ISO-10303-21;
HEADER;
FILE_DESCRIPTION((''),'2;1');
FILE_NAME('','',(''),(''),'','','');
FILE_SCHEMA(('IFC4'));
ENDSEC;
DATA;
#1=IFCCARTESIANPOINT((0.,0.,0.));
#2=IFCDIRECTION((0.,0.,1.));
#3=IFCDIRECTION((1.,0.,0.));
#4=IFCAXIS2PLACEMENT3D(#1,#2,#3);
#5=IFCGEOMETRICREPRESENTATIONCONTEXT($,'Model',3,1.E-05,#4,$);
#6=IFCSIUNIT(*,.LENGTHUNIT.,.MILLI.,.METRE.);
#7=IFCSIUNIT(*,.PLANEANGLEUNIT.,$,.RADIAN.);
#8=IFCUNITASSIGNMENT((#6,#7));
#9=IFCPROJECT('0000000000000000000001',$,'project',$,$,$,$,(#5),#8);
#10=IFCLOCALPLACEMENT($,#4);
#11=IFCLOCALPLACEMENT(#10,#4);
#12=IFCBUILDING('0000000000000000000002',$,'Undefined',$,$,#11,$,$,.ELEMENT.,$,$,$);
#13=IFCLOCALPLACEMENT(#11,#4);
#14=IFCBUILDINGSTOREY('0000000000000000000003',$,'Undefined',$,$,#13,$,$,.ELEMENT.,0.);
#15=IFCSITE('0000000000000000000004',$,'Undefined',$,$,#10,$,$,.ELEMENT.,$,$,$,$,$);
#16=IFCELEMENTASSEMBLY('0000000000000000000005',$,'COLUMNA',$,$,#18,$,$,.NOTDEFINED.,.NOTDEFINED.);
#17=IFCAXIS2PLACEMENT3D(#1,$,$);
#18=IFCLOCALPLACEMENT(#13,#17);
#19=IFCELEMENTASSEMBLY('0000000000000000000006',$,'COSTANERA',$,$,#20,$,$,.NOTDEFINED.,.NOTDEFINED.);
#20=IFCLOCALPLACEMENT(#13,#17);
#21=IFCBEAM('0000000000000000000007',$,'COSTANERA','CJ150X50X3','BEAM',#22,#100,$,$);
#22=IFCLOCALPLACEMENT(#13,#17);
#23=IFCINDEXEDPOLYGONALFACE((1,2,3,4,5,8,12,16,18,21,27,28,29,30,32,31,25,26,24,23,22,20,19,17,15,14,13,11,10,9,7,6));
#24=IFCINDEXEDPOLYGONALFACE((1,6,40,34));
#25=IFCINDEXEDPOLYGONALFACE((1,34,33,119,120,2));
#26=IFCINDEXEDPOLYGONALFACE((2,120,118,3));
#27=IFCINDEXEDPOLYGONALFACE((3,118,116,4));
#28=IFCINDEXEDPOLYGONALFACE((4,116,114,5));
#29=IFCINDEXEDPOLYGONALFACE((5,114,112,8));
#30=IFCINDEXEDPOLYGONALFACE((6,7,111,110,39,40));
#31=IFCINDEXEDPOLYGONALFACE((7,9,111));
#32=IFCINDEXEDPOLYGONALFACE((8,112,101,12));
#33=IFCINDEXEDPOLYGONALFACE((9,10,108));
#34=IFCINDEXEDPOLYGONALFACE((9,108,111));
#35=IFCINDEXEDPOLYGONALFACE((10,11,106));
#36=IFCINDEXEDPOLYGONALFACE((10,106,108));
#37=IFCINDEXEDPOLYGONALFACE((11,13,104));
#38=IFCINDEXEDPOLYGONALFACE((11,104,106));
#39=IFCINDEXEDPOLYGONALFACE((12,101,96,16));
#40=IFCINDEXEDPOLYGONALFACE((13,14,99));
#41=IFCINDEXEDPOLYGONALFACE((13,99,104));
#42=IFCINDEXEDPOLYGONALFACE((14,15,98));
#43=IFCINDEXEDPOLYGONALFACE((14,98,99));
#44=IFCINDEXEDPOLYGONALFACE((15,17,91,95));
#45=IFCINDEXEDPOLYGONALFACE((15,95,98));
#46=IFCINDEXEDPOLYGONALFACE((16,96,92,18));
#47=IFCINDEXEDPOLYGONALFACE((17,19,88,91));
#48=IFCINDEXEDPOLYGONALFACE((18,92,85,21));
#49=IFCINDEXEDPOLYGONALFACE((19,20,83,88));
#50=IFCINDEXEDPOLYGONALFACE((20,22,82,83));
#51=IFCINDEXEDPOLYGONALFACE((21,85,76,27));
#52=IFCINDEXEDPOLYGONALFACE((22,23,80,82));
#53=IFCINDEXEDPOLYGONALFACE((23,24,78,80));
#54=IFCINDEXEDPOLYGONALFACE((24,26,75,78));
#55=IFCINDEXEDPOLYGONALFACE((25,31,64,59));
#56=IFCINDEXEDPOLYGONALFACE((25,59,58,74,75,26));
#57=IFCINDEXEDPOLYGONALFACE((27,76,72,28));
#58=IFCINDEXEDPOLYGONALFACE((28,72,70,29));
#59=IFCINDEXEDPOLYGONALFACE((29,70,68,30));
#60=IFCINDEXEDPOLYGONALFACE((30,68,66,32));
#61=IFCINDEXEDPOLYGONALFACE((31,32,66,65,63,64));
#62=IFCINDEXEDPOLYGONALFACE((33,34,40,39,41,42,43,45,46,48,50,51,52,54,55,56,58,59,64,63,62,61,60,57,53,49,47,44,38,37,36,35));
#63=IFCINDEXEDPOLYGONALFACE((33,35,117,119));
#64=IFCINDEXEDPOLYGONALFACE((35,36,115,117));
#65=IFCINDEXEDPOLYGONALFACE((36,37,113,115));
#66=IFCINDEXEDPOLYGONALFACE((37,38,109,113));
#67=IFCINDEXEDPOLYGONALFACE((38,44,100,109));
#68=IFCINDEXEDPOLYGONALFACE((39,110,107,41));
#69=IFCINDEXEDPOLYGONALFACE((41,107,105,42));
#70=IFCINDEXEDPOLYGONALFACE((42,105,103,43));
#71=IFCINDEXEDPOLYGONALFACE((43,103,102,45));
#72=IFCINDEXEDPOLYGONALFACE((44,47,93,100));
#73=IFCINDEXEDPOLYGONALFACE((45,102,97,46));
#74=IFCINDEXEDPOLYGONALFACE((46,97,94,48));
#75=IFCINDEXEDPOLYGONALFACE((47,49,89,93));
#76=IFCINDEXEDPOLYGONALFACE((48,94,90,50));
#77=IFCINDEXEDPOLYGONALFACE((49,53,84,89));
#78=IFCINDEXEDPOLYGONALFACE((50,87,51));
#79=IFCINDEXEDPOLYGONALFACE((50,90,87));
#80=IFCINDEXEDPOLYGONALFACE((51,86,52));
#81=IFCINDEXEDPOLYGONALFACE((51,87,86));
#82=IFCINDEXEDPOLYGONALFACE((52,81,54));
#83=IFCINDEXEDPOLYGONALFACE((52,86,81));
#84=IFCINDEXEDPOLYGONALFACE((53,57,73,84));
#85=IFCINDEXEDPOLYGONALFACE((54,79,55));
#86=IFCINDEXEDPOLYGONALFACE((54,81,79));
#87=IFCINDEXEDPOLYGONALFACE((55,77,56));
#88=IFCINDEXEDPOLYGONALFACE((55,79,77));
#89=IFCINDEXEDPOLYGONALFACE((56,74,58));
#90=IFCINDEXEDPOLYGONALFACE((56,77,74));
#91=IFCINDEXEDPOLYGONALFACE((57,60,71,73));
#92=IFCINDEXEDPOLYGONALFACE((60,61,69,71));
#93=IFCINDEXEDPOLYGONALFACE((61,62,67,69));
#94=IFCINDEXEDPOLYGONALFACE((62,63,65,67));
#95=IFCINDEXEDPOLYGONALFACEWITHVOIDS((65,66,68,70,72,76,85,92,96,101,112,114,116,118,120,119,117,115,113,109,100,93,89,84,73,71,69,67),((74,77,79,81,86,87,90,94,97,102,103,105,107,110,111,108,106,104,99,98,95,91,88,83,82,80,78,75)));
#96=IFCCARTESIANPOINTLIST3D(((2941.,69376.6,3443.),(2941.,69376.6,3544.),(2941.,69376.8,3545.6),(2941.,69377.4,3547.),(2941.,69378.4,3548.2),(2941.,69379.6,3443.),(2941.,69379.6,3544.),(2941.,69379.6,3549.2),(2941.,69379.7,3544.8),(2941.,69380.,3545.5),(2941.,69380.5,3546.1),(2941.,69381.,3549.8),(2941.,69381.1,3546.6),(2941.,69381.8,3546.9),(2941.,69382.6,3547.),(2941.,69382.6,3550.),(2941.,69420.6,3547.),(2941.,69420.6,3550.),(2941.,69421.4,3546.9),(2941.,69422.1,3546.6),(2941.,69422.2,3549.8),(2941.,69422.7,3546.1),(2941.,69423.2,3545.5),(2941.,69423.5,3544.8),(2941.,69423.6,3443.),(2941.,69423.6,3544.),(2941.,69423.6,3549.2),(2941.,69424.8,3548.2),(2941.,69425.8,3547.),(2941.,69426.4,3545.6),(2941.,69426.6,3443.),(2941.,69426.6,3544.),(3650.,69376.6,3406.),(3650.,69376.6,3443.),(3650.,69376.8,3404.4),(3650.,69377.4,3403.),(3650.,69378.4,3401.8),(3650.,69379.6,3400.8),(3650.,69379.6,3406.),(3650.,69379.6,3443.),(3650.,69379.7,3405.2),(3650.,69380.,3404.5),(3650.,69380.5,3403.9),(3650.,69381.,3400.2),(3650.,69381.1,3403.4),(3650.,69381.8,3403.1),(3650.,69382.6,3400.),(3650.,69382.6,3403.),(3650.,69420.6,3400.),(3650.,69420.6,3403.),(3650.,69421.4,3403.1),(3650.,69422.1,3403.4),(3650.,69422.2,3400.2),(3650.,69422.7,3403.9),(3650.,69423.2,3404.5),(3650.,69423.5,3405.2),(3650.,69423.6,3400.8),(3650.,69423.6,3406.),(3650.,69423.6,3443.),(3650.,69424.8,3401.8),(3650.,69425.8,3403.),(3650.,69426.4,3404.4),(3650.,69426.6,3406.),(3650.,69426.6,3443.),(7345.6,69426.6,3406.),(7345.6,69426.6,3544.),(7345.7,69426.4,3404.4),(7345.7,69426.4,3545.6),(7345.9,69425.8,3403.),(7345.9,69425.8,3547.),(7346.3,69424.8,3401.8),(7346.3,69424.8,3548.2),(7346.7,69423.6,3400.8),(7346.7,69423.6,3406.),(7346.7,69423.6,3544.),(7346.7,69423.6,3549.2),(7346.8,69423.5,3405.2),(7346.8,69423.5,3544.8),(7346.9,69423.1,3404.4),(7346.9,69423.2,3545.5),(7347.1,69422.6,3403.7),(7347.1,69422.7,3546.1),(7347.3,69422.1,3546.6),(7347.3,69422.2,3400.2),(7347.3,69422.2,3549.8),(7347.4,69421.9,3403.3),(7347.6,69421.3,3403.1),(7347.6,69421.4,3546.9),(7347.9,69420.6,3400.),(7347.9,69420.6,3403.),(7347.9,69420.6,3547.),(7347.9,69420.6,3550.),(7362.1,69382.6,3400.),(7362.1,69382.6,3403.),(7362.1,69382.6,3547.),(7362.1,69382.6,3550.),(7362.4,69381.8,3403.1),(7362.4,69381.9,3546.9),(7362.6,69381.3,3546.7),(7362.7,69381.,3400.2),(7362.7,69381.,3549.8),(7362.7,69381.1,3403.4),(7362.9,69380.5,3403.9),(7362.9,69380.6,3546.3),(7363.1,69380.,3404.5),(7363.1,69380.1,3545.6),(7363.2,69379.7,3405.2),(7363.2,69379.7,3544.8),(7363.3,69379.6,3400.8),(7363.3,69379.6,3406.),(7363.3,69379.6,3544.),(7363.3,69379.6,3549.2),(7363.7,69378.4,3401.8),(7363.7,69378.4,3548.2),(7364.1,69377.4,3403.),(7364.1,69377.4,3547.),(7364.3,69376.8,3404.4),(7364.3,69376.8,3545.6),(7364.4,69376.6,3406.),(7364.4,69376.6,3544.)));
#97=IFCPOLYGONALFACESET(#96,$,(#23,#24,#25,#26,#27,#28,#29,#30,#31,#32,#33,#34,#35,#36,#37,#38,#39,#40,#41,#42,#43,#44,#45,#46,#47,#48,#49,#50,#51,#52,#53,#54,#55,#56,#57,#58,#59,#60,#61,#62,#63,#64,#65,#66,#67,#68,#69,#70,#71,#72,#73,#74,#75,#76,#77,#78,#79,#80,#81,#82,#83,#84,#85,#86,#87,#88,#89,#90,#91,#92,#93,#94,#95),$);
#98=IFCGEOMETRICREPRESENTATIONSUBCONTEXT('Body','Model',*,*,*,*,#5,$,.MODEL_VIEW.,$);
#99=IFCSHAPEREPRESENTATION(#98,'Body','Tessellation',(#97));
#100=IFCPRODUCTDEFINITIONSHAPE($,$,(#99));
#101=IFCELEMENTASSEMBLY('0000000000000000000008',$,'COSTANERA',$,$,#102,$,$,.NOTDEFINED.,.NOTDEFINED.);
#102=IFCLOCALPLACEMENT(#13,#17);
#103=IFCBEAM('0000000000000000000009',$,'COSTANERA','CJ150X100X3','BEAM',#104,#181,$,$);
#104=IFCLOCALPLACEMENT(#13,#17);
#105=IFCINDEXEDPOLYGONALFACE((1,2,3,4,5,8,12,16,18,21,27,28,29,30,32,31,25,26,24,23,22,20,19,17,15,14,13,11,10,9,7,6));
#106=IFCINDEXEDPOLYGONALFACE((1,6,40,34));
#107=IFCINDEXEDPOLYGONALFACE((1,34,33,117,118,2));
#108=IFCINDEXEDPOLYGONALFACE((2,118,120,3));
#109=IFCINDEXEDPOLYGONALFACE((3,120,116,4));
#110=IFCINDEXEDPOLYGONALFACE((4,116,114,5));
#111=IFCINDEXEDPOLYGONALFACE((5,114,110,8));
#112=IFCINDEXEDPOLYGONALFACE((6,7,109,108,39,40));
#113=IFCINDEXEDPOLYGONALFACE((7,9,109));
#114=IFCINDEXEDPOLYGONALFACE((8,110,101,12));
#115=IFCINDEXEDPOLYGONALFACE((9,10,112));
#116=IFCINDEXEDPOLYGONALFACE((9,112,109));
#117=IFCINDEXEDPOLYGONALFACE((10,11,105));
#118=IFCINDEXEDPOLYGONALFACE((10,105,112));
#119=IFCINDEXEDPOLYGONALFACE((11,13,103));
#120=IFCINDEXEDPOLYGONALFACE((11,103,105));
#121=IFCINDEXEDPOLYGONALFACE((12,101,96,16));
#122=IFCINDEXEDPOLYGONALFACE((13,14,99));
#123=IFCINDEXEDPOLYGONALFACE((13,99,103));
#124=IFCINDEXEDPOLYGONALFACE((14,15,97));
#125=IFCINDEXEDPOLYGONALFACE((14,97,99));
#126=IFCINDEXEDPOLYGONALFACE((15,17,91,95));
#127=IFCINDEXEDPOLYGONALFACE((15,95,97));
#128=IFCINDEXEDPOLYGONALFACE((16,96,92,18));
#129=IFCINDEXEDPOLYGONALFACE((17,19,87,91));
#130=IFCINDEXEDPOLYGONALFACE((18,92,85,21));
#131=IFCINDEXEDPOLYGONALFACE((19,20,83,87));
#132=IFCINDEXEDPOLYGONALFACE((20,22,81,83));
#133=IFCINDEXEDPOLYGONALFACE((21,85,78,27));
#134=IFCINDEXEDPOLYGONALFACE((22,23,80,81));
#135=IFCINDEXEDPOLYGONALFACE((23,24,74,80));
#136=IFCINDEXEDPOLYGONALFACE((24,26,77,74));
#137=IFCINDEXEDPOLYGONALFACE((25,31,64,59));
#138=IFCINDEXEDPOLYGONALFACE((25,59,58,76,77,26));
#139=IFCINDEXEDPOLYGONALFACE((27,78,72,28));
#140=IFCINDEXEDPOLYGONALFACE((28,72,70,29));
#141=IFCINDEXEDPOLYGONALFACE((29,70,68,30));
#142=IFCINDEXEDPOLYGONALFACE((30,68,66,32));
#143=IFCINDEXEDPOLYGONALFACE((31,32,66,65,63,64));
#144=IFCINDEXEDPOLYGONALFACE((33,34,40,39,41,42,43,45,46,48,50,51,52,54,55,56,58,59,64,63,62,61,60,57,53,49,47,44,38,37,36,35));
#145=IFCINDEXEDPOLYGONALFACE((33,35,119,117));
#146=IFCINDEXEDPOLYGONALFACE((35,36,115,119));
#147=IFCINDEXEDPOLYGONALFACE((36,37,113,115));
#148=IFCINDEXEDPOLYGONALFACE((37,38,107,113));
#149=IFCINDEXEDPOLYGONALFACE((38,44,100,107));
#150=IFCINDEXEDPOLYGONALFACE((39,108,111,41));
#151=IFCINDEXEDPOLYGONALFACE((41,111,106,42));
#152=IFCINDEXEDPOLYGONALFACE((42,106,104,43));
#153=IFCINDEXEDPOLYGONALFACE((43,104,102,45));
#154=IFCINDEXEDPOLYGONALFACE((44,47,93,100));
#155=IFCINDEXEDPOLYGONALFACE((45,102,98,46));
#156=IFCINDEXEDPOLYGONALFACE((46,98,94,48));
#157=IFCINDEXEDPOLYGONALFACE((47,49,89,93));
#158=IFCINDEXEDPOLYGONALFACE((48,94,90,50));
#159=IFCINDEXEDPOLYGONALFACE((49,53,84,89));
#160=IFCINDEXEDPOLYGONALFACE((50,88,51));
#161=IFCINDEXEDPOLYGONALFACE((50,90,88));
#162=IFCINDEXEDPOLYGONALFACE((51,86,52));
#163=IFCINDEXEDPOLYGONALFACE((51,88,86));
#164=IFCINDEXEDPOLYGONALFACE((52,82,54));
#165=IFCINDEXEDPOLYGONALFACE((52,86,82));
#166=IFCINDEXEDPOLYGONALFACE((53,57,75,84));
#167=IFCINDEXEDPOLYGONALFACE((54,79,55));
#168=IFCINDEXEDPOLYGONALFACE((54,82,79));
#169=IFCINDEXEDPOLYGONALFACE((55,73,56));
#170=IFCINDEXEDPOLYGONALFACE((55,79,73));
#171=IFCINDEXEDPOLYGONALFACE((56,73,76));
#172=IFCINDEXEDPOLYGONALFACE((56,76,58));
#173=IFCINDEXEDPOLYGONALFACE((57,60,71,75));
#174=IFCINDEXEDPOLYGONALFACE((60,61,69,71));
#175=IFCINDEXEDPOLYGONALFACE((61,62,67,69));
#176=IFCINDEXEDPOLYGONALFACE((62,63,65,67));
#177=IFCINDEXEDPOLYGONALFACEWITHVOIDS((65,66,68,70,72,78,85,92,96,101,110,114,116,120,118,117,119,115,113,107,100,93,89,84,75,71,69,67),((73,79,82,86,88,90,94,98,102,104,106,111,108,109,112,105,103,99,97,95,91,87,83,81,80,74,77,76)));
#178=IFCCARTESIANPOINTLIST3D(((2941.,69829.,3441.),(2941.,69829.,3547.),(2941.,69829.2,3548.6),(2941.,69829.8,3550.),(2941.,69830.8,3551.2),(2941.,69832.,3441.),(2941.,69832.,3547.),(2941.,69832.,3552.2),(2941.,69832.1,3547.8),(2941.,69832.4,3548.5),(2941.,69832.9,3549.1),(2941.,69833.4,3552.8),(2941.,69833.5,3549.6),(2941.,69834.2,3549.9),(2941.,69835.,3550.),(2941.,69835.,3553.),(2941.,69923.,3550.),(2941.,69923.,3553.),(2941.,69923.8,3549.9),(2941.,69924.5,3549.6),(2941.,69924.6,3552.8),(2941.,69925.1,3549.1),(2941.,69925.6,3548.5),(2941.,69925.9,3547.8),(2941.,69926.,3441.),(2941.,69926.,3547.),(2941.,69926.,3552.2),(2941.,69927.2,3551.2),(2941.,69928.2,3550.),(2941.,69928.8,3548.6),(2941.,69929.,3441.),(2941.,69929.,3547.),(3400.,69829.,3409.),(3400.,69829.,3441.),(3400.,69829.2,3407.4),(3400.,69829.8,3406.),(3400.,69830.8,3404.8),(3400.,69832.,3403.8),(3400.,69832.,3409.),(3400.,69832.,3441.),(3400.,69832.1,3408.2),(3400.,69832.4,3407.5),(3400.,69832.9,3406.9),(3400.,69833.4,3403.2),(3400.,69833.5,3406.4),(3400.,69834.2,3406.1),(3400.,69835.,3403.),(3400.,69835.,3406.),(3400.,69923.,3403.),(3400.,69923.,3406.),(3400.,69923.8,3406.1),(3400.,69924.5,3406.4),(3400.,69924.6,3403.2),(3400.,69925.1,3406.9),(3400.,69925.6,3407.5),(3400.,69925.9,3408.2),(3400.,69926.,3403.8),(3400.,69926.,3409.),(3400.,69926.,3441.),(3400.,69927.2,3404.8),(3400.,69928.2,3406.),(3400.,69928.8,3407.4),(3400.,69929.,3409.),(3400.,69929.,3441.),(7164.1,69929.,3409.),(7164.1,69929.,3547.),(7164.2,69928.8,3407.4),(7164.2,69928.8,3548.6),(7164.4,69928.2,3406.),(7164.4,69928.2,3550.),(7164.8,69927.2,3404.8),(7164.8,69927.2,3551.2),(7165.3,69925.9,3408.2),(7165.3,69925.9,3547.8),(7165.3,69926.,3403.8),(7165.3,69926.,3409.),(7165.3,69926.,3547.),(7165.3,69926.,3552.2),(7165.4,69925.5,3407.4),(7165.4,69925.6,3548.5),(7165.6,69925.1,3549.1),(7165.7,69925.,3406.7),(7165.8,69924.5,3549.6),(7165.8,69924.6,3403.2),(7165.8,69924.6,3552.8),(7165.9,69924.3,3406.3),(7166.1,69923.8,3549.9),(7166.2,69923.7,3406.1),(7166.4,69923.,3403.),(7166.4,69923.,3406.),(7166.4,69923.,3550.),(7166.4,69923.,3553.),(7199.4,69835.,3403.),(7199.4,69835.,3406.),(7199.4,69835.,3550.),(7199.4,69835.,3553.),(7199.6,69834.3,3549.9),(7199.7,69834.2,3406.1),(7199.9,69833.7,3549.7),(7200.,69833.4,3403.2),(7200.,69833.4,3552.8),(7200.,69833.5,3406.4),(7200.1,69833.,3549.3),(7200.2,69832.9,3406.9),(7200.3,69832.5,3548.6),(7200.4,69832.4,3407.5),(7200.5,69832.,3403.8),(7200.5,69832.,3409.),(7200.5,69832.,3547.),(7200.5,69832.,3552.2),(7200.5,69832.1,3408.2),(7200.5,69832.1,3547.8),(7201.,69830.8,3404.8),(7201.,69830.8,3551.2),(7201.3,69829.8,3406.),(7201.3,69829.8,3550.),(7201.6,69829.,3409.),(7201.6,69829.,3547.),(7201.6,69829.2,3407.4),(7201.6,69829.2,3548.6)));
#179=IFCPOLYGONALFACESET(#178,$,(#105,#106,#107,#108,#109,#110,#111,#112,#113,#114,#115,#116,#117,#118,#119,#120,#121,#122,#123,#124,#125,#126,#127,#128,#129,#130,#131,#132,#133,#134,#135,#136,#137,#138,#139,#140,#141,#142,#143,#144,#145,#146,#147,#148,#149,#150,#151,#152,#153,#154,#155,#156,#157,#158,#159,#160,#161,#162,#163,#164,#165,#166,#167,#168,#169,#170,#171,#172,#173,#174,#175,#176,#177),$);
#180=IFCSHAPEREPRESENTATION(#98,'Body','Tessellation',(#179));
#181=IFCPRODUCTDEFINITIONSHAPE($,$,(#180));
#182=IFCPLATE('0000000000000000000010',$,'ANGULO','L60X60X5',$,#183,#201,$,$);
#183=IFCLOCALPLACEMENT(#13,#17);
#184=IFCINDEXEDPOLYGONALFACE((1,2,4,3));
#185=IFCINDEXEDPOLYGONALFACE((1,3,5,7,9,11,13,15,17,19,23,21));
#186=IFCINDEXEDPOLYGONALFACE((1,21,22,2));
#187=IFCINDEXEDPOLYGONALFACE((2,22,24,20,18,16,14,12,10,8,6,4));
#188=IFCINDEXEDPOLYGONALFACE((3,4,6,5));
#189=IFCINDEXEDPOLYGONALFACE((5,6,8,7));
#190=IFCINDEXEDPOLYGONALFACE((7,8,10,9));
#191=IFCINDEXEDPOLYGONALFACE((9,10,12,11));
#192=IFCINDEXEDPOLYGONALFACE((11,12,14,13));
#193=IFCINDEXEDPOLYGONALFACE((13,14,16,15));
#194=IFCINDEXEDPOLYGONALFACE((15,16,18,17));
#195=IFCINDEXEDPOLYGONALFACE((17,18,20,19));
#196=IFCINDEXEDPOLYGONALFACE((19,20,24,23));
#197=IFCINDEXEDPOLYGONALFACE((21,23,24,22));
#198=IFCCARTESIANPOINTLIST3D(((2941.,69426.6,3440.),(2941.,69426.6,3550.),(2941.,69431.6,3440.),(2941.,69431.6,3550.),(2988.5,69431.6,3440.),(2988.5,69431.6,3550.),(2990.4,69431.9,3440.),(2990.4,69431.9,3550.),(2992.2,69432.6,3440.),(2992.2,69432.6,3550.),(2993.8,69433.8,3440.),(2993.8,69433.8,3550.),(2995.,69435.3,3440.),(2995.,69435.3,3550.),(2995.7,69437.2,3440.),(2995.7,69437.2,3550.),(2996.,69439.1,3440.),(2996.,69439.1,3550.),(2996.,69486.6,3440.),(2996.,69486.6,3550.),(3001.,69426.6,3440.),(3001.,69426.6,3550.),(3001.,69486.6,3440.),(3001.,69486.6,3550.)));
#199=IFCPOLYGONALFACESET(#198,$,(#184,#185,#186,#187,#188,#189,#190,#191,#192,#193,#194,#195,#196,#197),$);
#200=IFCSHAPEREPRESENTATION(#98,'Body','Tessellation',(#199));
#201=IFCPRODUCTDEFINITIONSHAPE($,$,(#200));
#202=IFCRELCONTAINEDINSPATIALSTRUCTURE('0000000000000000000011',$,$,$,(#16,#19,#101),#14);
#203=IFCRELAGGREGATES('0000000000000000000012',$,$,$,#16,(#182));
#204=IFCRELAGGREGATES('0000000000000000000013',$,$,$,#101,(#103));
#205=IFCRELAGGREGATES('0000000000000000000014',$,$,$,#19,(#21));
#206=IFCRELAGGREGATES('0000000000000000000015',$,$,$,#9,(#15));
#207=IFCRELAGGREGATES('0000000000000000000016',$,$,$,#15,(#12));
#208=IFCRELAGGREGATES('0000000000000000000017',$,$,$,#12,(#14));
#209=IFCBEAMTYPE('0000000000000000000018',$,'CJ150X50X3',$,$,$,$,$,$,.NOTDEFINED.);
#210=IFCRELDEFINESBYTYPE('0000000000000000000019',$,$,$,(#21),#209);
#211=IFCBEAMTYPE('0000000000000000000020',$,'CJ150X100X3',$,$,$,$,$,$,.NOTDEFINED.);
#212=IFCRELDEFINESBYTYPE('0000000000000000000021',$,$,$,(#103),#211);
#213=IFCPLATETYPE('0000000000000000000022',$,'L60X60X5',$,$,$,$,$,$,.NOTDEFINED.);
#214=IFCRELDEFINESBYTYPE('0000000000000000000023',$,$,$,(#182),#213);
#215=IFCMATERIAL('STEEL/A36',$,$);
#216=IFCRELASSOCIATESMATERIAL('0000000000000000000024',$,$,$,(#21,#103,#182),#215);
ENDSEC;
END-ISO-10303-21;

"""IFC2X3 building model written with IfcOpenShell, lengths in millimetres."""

from ifc_helpers import new_model, si_unit, frame, origin_with_axes, origin_2d_with_axis, place, context, subcontext, project, spatial, polyline, hollow_rectangle, l_section, outline, extrude, boolean, halfspace, material, type_object, element, aggregate, save


model = new_model("IFC2X3")

# Units and contexts
model_context = context("Model", 3, precision=1e-05, world=origin_with_axes())
body_context = subcontext(model_context, "Body", "Model", "MODEL_VIEW")
ifc_project = project(units=[si_unit("LENGTHUNIT", "METRE", prefix="MILLI"), si_unit("PLANEANGLEUNIT", "RADIAN")], contexts=[model_context])

# Site, building, storey
site_placement = place(None, origin_with_axes())
site = spatial("IfcSite", under=ifc_project, at=site_placement, Name="Undefined", CompositionType="ELEMENT")
building_placement = place(site_placement, origin_with_axes())
building = spatial("IfcBuilding", under=site, at=building_placement, Name="Undefined", CompositionType="ELEMENT")
storey_placement = place(building_placement, origin_with_axes())
storey = spatial("IfcBuildingStorey", under=building, at=storey_placement, Name="Undefined", CompositionType="ELEMENT", Elevation=0.0)

# Element assembly
assembly_1_placement = place(storey_placement, origin_with_axes())
assembly_1 = element("IfcElementAssembly", 1, at=assembly_1_placement, inside=storey, Name="COLUMNA", AssemblyPlace="NOTDEFINED", PredefinedType="NOTDEFINED")
ifc_material_1 = material(Name="STEEL/A36")

# Element assemblies, beams
assembly_2_placement = place(storey_placement, origin_with_axes())
assembly_2 = element("IfcElementAssembly", 2, at=assembly_2_placement, inside=storey, Name="COSTANERA", AssemblyPlace="NOTDEFINED", PredefinedType="NOTDEFINED")
beam_type_1 = type_object("IfcBeamType", Name="CJ150X50X3", PredefinedType="NOTDEFINED")
beam_1_placement = place(assembly_2_placement, frame((2941.0, 69401.6, 3475.0), z_axis=(0.0, 0.0, 1.0), x_axis=(1.0, 0.0, 0.0)))
beam_1 = element("IfcBeam", 3, at=beam_1_placement, type_object=beam_type_1, material=ifc_material_1, Name="COSTANERA", Description="CJ150X50X3", ObjectType="BEAM", context=body_context, shape_type="CSG", body=[
    boolean("DIFFERENCE", boolean("DIFFERENCE", extrude(hollow_rectangle(XDim=50.0, YDim=150.0, WallThickness=3.0, InnerFilletRadius=3.0, OuterFilletRadius=6.0, at=origin_2d_with_axis()), frame((4423.5, 0.0, 0.0), z_axis=(-1.0, 0.0, 0.0), x_axis=(0.0, -1.0, 0.0)), (0.0, 0.0, 1.0), 4423.5), extrude(outline(polyline([(0.0, 0.0), (896.0, 0.0), (896.0, 48.0), (0.0, 48.0), (0.0, 0.0)])), frame((-187.0, -52.5, -32.0), z_axis=(0.0, 1.0, 0.0), x_axis=(1.0, 0.0, 0.0)), (0.0, 0.0, 1.0), 105.0)), halfspace(frame((4404.6, 25.0, 0.0), z_axis=(-0.936213, -0.351433, 0.0), x_axis=(0.0, 0.0, 1.0)), True)),
])
assembly_3_placement = place(storey_placement, origin_with_axes())
assembly_3 = element("IfcElementAssembly", 4, at=assembly_3_placement, inside=storey, Name="COSTANERA", AssemblyPlace="NOTDEFINED", PredefinedType="NOTDEFINED")
beam_type_2 = type_object("IfcBeamType", Name="CJ150X100X3", PredefinedType="NOTDEFINED")
beam_2_placement = place(assembly_3_placement, frame((2941.0, 69879.0, 3478.0), z_axis=(0.0, 0.0, 1.0), x_axis=(1.0, 0.0, 0.0)))
beam_2 = element("IfcBeam", 5, at=beam_2_placement, type_object=beam_type_2, material=ifc_material_1, Name="COSTANERA", Description="CJ150X100X3", ObjectType="BEAM", context=body_context, shape_type="CSG", body=[
    boolean("DIFFERENCE", boolean("DIFFERENCE", extrude(hollow_rectangle(XDim=100.0, YDim=150.0, WallThickness=3.0, InnerFilletRadius=3.0, OuterFilletRadius=6.0, at=origin_2d_with_axis()), frame((4260.8, 0.0, 0.0), z_axis=(-1.0, 0.0, 0.0), x_axis=(0.0, -1.0, 0.0)), (0.0, 0.0, 1.0), 4260.8), extrude(outline(polyline([(0.0, 0.0), (646.0, 0.0), (646.0, 43.0), (0.0, 43.0), (0.0, 0.0)])), frame((-187.0, -52.5, -37.0), z_axis=(0.0, 1.0, 0.0), x_axis=(1.0, 0.0, 0.0)), (0.0, 0.0, 1.0), 105.0)), halfspace(frame((4223.1, 50.0, 0.0), z_axis=(-0.936354, -0.351057, 0.0), x_axis=(0.0, 0.0, 1.0)), True)),
])

# Plate
plate_type_1 = type_object("IfcPlateType", Name="L60X60X5", PredefinedType="NOTDEFINED")
plate_1_placement = place(assembly_1_placement, frame((2971.0, 69456.6, 3440.0), z_axis=(0.0, 1.0, 0.0), x_axis=(0.0, 0.0, 1.0)))
plate_1 = element("IfcPlate", 6, at=plate_1_placement, type_object=plate_type_1, material=ifc_material_1, Name="ANGULO", Description="L60X60X5", context=body_context, shape_type="SweptSolid", body=[
    extrude(l_section(Depth=60.0, Width=60.0, Thickness=5.0, FilletRadius=7.5, at=origin_2d_with_axis()), frame((110.0, 0.0, 0.0), z_axis=(-1.0, 0.0, 0.0), x_axis=(0.0, -1.0, 0.0)), (0.0, 0.0, 1.0), 110.0),
])

aggregate(assembly_1, [plate_1])

aggregate(assembly_3, [beam_2])
aggregate(assembly_2, [beam_1])

save(model, "model.ifc")
